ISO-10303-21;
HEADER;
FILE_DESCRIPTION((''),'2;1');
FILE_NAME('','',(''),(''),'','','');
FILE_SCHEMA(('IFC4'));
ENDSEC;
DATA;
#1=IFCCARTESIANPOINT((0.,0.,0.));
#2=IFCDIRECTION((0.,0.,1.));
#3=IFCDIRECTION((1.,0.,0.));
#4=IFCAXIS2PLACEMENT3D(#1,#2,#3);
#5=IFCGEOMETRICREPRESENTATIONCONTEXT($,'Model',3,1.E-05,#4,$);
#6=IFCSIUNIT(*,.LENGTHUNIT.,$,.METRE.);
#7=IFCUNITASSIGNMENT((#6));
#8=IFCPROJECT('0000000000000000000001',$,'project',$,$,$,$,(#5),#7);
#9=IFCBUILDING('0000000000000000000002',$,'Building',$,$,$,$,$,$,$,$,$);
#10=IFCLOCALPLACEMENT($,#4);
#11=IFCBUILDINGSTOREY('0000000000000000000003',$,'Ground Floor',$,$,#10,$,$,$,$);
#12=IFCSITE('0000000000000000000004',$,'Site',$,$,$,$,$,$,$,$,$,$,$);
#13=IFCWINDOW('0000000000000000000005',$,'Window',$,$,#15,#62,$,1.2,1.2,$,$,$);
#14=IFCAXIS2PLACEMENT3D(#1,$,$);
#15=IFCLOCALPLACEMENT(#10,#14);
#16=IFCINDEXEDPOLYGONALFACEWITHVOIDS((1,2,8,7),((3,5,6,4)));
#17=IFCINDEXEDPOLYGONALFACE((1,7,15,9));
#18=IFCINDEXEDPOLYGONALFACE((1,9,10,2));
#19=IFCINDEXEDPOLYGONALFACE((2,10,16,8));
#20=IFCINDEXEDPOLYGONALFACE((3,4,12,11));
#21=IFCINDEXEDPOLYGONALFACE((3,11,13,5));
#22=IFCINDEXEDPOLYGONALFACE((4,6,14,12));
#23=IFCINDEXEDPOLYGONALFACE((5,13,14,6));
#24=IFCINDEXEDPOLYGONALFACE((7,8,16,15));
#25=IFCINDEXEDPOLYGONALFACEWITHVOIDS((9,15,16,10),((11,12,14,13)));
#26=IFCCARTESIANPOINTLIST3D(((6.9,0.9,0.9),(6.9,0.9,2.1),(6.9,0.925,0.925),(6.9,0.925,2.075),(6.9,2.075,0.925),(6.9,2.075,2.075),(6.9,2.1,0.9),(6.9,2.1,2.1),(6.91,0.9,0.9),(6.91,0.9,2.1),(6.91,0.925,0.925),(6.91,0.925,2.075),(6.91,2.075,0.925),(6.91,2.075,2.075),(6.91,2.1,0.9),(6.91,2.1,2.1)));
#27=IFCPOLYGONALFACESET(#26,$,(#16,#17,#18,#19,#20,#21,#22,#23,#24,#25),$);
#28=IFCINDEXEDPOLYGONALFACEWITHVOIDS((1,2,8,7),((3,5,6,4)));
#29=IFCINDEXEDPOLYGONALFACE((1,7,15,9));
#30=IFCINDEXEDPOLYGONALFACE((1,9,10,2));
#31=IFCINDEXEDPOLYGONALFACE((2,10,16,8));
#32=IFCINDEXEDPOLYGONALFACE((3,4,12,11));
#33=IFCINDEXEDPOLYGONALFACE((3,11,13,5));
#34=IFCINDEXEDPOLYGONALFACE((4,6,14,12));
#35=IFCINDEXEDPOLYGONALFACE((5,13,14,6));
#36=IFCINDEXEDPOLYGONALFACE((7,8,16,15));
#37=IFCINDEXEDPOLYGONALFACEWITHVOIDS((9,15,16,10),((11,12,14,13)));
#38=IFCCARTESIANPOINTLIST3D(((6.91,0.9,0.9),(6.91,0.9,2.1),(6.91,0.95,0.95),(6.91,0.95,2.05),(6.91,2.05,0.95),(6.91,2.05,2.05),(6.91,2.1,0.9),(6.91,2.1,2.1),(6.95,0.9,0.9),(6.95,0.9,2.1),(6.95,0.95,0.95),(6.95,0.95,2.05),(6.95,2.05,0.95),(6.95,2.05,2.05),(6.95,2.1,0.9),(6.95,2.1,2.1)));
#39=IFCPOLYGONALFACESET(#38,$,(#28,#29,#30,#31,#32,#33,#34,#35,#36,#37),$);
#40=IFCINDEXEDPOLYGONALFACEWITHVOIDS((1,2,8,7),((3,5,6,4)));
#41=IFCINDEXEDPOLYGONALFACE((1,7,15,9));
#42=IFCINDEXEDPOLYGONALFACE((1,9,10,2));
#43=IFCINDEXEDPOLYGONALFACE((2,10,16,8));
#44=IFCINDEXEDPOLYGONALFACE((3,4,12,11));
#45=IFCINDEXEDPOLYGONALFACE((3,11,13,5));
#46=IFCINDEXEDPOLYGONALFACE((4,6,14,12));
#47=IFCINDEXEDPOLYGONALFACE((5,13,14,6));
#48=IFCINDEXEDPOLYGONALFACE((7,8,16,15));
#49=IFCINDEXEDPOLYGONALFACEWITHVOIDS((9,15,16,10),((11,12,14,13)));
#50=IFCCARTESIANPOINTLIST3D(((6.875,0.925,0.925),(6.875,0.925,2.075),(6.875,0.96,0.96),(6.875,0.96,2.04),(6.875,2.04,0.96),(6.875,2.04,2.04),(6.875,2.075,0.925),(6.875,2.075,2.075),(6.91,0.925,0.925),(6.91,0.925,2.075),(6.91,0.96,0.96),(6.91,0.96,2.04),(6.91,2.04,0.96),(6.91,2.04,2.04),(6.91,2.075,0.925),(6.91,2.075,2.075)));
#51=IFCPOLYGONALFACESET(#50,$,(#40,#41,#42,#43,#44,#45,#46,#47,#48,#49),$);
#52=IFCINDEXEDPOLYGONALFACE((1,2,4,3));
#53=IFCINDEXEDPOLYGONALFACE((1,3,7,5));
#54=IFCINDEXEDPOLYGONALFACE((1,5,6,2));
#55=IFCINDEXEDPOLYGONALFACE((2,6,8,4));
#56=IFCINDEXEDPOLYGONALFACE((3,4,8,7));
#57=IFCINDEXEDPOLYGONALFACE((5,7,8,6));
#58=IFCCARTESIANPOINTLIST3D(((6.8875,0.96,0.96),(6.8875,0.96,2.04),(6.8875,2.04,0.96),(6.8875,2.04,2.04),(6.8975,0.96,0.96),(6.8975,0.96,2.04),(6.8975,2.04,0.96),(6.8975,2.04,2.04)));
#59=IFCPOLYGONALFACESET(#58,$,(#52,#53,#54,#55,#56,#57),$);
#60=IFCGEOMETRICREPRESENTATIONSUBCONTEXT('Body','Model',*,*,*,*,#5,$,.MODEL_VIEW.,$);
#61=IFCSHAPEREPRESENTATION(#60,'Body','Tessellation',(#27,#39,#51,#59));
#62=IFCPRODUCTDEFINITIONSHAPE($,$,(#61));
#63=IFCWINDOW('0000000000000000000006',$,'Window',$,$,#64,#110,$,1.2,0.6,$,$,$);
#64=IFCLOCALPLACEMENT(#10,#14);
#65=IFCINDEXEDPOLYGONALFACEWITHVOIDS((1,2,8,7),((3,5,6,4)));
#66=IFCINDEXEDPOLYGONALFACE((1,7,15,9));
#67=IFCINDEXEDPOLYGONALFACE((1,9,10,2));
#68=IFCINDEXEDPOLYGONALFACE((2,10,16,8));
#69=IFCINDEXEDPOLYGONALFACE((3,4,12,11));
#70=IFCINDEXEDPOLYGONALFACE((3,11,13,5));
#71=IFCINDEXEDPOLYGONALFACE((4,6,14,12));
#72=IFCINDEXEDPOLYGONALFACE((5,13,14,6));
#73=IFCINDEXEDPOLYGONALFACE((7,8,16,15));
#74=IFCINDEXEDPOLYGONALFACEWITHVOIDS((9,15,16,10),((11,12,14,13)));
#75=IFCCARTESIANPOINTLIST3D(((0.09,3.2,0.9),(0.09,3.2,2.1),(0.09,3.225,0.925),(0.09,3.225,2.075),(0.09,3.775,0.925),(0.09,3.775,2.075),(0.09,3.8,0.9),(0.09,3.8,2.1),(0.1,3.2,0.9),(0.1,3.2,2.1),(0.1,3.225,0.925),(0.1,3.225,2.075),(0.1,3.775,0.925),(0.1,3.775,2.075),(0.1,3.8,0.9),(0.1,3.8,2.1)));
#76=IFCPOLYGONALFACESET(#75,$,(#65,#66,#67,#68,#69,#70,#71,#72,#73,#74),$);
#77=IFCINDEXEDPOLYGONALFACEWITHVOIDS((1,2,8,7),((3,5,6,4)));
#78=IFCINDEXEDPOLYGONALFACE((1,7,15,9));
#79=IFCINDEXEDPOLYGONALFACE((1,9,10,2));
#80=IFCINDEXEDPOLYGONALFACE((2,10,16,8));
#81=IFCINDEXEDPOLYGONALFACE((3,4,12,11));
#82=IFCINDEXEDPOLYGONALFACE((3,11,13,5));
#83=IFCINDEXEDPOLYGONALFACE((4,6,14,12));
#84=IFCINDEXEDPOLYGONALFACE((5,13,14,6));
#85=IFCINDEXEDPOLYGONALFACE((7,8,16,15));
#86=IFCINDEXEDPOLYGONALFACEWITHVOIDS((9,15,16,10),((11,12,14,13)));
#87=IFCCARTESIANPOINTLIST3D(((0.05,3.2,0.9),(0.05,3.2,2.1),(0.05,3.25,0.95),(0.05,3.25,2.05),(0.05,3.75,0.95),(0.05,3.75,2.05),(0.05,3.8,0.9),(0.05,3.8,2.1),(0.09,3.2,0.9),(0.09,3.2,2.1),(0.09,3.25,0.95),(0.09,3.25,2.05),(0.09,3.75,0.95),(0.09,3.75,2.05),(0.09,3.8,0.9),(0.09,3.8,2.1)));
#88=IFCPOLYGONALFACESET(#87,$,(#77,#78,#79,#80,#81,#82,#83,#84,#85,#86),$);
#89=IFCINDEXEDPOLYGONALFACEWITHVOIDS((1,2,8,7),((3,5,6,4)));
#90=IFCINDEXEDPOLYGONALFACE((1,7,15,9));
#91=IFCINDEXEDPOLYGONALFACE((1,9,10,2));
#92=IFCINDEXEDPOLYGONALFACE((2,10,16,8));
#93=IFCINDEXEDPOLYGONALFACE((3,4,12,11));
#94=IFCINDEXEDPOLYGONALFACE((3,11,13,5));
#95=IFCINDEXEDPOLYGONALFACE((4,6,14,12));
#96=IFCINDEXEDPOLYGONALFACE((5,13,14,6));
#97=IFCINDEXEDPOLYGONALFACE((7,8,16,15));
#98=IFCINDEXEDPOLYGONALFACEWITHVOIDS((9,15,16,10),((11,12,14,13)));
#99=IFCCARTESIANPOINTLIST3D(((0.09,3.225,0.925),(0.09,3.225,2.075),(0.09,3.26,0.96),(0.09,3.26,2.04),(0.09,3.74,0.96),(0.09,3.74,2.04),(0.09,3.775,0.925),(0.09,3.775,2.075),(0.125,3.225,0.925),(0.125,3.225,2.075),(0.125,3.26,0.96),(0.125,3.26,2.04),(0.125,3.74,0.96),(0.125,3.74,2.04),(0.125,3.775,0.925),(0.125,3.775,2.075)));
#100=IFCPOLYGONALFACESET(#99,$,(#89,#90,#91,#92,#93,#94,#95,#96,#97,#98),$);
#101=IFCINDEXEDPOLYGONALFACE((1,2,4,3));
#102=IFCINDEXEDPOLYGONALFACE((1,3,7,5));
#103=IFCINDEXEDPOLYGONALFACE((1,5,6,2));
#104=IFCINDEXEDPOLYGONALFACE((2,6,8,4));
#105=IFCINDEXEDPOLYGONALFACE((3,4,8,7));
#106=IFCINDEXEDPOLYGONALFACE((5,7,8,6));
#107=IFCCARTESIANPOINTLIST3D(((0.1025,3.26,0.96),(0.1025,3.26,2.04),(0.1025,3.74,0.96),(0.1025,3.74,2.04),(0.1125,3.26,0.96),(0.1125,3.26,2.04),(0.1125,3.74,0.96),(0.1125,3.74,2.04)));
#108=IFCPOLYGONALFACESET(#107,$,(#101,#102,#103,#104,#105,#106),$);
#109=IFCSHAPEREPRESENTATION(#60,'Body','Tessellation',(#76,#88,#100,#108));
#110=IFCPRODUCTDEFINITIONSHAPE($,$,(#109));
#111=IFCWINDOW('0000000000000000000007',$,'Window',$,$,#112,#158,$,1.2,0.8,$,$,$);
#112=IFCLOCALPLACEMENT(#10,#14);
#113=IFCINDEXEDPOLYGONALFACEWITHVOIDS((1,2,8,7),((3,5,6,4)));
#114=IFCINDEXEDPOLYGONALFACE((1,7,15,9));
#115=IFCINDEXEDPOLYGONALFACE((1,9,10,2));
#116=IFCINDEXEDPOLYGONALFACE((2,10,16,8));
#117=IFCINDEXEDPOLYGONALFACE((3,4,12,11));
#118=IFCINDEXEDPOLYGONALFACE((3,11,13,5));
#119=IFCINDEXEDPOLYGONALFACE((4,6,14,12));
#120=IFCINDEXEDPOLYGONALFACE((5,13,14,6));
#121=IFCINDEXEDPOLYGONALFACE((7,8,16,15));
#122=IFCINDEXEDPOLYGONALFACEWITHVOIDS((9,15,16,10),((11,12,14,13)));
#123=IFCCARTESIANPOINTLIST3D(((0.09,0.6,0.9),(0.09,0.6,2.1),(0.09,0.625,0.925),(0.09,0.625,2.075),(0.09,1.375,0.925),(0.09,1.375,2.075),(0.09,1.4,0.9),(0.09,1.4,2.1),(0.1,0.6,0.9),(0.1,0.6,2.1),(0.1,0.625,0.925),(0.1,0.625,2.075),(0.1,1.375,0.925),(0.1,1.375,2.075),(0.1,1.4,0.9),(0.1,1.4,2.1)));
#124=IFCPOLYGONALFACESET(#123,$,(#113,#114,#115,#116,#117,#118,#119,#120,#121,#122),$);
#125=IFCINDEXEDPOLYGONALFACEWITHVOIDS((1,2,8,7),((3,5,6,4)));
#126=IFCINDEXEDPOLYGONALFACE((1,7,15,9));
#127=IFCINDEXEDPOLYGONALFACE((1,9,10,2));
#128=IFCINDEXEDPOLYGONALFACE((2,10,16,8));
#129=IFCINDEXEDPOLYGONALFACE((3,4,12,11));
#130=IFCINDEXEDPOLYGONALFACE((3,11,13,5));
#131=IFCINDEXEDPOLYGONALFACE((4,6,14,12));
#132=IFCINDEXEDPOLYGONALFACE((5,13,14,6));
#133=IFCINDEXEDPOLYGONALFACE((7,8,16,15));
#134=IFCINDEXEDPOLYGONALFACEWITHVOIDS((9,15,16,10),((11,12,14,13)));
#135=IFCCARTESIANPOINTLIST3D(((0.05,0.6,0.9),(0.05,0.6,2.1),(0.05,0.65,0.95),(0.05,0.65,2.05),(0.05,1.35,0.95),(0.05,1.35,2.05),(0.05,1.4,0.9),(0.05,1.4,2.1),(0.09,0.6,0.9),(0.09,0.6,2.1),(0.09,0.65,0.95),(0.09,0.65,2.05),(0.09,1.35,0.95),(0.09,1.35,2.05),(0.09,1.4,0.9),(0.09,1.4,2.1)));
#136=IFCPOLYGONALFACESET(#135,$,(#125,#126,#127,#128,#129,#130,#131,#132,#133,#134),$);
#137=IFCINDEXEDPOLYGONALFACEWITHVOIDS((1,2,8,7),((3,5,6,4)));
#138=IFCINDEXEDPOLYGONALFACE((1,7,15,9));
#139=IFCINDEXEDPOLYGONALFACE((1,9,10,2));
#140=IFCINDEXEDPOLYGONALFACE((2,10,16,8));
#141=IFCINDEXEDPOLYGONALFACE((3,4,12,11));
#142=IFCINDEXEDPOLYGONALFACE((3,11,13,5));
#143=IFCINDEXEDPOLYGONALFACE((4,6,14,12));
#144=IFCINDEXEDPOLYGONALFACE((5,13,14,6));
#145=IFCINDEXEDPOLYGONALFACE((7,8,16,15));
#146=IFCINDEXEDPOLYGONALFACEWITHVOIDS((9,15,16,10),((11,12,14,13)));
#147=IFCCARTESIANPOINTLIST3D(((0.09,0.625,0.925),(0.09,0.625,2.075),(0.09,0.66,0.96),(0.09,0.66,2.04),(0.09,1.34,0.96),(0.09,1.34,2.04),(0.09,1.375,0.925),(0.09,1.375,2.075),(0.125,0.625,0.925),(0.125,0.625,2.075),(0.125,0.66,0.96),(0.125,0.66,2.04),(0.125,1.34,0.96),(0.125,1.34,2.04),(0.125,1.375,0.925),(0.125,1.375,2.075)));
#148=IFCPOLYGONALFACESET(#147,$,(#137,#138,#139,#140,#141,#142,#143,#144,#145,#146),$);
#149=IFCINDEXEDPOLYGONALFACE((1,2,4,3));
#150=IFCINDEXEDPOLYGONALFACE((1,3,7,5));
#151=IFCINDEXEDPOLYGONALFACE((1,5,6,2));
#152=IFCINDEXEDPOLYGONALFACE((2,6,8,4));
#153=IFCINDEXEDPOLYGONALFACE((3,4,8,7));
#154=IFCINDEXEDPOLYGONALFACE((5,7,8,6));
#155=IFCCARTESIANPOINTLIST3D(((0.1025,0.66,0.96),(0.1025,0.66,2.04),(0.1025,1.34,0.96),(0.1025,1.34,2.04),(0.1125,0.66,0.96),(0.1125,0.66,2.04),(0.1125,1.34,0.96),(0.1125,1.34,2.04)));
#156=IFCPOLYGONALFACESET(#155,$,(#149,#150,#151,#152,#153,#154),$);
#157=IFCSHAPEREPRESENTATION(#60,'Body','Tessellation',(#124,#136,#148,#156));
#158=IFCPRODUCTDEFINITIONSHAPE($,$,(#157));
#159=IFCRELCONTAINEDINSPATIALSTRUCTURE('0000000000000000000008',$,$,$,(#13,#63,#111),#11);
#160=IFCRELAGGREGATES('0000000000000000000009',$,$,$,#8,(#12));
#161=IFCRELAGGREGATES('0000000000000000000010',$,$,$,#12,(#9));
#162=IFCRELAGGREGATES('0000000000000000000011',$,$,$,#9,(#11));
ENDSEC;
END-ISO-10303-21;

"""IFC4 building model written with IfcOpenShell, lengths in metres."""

from ifc_helpers import new_model, si_unit, frame, origin_with_axes, place, context, subcontext, project, spatial, line, indexed_curve, outline, extrude, element, save


model = new_model("IFC4")

# Units and contexts
model_context = context("Model", 3, precision=1e-05, world=origin_with_axes())
body_context = subcontext(model_context, "Body", "Model", "MODEL_VIEW")
ifc_project = project(units=[si_unit("LENGTHUNIT", "METRE")], contexts=[model_context])

# Site, building, storey
site = spatial("IfcSite", under=ifc_project, Name="Site")
building = spatial("IfcBuilding", under=site, Name="Building")
storey_placement = place(None, origin_with_axes())
storey = spatial("IfcBuildingStorey", under=building, at=storey_placement, Name="Ground Floor")

# Windows
window_1_placement = place(storey_placement, frame((7.0, 0.9, 0.9), z_axis=(0.0, 0.0, 1.0), x_axis=(0.0, 1.0, 0.0)))
element("IfcWindow", 1, at=window_1_placement, inside=storey, Name="Window", OverallHeight=1.2, OverallWidth=1.2, context=body_context, shape_type="SweptSolid", body=[
    extrude(outline(indexed_curve([(0.0, 0.0), (1.2, 0.0), (1.2, 1.2), (0.0, 1.2)], segments=[line(1, 2, 3, 4, 1)]), holes=[indexed_curve([(0.025, 0.025), (1.175, 0.025), (1.175, 1.175), (0.025, 1.175)], segments=[line(1, 2, 3, 4, 1)])]), frame((0.0, 0.09, 0.0), z_axis=(0.0, -1.0, 0.0), x_axis=(1.0, 0.0, 0.0)), (0.0, 0.0, -1.0), 0.01),
    extrude(outline(indexed_curve([(0.0, 0.0), (1.2, 0.0), (1.2, 1.2), (0.0, 1.2)], segments=[line(1, 2, 3, 4, 1)]), holes=[indexed_curve([(0.05, 0.05), (1.15, 0.05), (1.15, 1.15), (0.05, 1.15)], segments=[line(1, 2, 3, 4, 1)])]), frame((0.0, 0.05, 0.0), z_axis=(0.0, -1.0, 0.0), x_axis=(1.0, 0.0, 0.0)), (0.0, 0.0, -1.0), 0.04),
    extrude(outline(indexed_curve([(0.0, 0.0), (1.15, 0.0), (1.15, 1.15), (0.0, 1.15)], segments=[line(1, 2, 3, 4, 1)]), holes=[indexed_curve([(0.035, 0.035), (1.115, 0.035), (1.115, 1.115), (0.035, 1.115)], segments=[line(1, 2, 3, 4, 1)])]), frame((0.025, 0.09, 0.025), z_axis=(0.0, -1.0, 0.0), x_axis=(1.0, 0.0, 0.0)), (0.0, 0.0, -1.0), 0.035),
    extrude(outline(indexed_curve([(0.035, 0.035), (1.115, 0.035), (1.115, 1.115), (0.035, 1.115)], segments=[line(1, 2, 3, 4, 1)])), frame((0.025, 0.1025, 0.025), z_axis=(0.0, -1.0, 0.0), x_axis=(1.0, 0.0, 0.0)), (0.0, 0.0, -1.0), 0.01),
])
window_2_placement = place(storey_placement, frame((0.0, 3.8, 0.9), z_axis=(0.0, 0.0, 1.0), x_axis=(0.0, -1.0, 0.0)))
element("IfcWindow", 2, at=window_2_placement, inside=storey, Name="Window", OverallHeight=1.2, OverallWidth=0.6, context=body_context, shape_type="SweptSolid", body=[
    extrude(outline(indexed_curve([(0.0, 0.0), (0.6, 0.0), (0.6, 1.2), (0.0, 1.2)], segments=[line(1, 2, 3, 4, 1)]), holes=[indexed_curve([(0.025, 0.025), (0.575, 0.025), (0.575, 1.175), (0.025, 1.175)], segments=[line(1, 2, 3, 4, 1)])]), frame((0.0, 0.09, 0.0), z_axis=(0.0, -1.0, 0.0), x_axis=(1.0, 0.0, 0.0)), (0.0, 0.0, -1.0), 0.01),
    extrude(outline(indexed_curve([(0.0, 0.0), (0.6, 0.0), (0.6, 1.2), (0.0, 1.2)], segments=[line(1, 2, 3, 4, 1)]), holes=[indexed_curve([(0.05, 0.05), (0.55, 0.05), (0.55, 1.15), (0.05, 1.15)], segments=[line(1, 2, 3, 4, 1)])]), frame((0.0, 0.05, 0.0), z_axis=(0.0, -1.0, 0.0), x_axis=(1.0, 0.0, 0.0)), (0.0, 0.0, -1.0), 0.04),
    extrude(outline(indexed_curve([(0.0, 0.0), (0.55, 0.0), (0.55, 1.15), (0.0, 1.15)], segments=[line(1, 2, 3, 4, 1)]), holes=[indexed_curve([(0.035, 0.035), (0.515, 0.035), (0.515, 1.115), (0.035, 1.115)], segments=[line(1, 2, 3, 4, 1)])]), frame((0.025, 0.09, 0.025), z_axis=(0.0, -1.0, 0.0), x_axis=(1.0, 0.0, 0.0)), (0.0, 0.0, -1.0), 0.035),
    extrude(outline(indexed_curve([(0.035, 0.035), (0.515, 0.035), (0.515, 1.115), (0.035, 1.115)], segments=[line(1, 2, 3, 4, 1)])), frame((0.025, 0.1025, 0.025), z_axis=(0.0, -1.0, 0.0), x_axis=(1.0, 0.0, 0.0)), (0.0, 0.0, -1.0), 0.01),
])
window_3_placement = place(storey_placement, frame((0.0, 1.4, 0.9), z_axis=(0.0, 0.0, 1.0), x_axis=(0.0, -1.0, 0.0)))
element("IfcWindow", 3, at=window_3_placement, inside=storey, Name="Window", OverallHeight=1.2, OverallWidth=0.8, context=body_context, shape_type="SweptSolid", body=[
    extrude(outline(indexed_curve([(0.0, 0.0), (0.8, 0.0), (0.8, 1.2), (0.0, 1.2)], segments=[line(1, 2, 3, 4, 1)]), holes=[indexed_curve([(0.025, 0.025), (0.775, 0.025), (0.775, 1.175), (0.025, 1.175)], segments=[line(1, 2, 3, 4, 1)])]), frame((0.0, 0.09, 0.0), z_axis=(0.0, -1.0, 0.0), x_axis=(1.0, 0.0, 0.0)), (0.0, 0.0, -1.0), 0.01),
    extrude(outline(indexed_curve([(0.0, 0.0), (0.8, 0.0), (0.8, 1.2), (0.0, 1.2)], segments=[line(1, 2, 3, 4, 1)]), holes=[indexed_curve([(0.05, 0.05), (0.75, 0.05), (0.75, 1.15), (0.05, 1.15)], segments=[line(1, 2, 3, 4, 1)])]), frame((0.0, 0.05, 0.0), z_axis=(0.0, -1.0, 0.0), x_axis=(1.0, 0.0, 0.0)), (0.0, 0.0, -1.0), 0.04),
    extrude(outline(indexed_curve([(0.0, 0.0), (0.75, 0.0), (0.75, 1.15), (0.0, 1.15)], segments=[line(1, 2, 3, 4, 1)]), holes=[indexed_curve([(0.035, 0.035), (0.715, 0.035), (0.715, 1.115), (0.035, 1.115)], segments=[line(1, 2, 3, 4, 1)])]), frame((0.025, 0.09, 0.025), z_axis=(0.0, -1.0, 0.0), x_axis=(1.0, 0.0, 0.0)), (0.0, 0.0, -1.0), 0.035),
    extrude(outline(indexed_curve([(0.035, 0.035), (0.715, 0.035), (0.715, 1.115), (0.035, 1.115)], segments=[line(1, 2, 3, 4, 1)])), frame((0.025, 0.1025, 0.025), z_axis=(0.0, -1.0, 0.0), x_axis=(1.0, 0.0, 0.0)), (0.0, 0.0, -1.0), 0.01),
])

save(model, "model.ifc")
